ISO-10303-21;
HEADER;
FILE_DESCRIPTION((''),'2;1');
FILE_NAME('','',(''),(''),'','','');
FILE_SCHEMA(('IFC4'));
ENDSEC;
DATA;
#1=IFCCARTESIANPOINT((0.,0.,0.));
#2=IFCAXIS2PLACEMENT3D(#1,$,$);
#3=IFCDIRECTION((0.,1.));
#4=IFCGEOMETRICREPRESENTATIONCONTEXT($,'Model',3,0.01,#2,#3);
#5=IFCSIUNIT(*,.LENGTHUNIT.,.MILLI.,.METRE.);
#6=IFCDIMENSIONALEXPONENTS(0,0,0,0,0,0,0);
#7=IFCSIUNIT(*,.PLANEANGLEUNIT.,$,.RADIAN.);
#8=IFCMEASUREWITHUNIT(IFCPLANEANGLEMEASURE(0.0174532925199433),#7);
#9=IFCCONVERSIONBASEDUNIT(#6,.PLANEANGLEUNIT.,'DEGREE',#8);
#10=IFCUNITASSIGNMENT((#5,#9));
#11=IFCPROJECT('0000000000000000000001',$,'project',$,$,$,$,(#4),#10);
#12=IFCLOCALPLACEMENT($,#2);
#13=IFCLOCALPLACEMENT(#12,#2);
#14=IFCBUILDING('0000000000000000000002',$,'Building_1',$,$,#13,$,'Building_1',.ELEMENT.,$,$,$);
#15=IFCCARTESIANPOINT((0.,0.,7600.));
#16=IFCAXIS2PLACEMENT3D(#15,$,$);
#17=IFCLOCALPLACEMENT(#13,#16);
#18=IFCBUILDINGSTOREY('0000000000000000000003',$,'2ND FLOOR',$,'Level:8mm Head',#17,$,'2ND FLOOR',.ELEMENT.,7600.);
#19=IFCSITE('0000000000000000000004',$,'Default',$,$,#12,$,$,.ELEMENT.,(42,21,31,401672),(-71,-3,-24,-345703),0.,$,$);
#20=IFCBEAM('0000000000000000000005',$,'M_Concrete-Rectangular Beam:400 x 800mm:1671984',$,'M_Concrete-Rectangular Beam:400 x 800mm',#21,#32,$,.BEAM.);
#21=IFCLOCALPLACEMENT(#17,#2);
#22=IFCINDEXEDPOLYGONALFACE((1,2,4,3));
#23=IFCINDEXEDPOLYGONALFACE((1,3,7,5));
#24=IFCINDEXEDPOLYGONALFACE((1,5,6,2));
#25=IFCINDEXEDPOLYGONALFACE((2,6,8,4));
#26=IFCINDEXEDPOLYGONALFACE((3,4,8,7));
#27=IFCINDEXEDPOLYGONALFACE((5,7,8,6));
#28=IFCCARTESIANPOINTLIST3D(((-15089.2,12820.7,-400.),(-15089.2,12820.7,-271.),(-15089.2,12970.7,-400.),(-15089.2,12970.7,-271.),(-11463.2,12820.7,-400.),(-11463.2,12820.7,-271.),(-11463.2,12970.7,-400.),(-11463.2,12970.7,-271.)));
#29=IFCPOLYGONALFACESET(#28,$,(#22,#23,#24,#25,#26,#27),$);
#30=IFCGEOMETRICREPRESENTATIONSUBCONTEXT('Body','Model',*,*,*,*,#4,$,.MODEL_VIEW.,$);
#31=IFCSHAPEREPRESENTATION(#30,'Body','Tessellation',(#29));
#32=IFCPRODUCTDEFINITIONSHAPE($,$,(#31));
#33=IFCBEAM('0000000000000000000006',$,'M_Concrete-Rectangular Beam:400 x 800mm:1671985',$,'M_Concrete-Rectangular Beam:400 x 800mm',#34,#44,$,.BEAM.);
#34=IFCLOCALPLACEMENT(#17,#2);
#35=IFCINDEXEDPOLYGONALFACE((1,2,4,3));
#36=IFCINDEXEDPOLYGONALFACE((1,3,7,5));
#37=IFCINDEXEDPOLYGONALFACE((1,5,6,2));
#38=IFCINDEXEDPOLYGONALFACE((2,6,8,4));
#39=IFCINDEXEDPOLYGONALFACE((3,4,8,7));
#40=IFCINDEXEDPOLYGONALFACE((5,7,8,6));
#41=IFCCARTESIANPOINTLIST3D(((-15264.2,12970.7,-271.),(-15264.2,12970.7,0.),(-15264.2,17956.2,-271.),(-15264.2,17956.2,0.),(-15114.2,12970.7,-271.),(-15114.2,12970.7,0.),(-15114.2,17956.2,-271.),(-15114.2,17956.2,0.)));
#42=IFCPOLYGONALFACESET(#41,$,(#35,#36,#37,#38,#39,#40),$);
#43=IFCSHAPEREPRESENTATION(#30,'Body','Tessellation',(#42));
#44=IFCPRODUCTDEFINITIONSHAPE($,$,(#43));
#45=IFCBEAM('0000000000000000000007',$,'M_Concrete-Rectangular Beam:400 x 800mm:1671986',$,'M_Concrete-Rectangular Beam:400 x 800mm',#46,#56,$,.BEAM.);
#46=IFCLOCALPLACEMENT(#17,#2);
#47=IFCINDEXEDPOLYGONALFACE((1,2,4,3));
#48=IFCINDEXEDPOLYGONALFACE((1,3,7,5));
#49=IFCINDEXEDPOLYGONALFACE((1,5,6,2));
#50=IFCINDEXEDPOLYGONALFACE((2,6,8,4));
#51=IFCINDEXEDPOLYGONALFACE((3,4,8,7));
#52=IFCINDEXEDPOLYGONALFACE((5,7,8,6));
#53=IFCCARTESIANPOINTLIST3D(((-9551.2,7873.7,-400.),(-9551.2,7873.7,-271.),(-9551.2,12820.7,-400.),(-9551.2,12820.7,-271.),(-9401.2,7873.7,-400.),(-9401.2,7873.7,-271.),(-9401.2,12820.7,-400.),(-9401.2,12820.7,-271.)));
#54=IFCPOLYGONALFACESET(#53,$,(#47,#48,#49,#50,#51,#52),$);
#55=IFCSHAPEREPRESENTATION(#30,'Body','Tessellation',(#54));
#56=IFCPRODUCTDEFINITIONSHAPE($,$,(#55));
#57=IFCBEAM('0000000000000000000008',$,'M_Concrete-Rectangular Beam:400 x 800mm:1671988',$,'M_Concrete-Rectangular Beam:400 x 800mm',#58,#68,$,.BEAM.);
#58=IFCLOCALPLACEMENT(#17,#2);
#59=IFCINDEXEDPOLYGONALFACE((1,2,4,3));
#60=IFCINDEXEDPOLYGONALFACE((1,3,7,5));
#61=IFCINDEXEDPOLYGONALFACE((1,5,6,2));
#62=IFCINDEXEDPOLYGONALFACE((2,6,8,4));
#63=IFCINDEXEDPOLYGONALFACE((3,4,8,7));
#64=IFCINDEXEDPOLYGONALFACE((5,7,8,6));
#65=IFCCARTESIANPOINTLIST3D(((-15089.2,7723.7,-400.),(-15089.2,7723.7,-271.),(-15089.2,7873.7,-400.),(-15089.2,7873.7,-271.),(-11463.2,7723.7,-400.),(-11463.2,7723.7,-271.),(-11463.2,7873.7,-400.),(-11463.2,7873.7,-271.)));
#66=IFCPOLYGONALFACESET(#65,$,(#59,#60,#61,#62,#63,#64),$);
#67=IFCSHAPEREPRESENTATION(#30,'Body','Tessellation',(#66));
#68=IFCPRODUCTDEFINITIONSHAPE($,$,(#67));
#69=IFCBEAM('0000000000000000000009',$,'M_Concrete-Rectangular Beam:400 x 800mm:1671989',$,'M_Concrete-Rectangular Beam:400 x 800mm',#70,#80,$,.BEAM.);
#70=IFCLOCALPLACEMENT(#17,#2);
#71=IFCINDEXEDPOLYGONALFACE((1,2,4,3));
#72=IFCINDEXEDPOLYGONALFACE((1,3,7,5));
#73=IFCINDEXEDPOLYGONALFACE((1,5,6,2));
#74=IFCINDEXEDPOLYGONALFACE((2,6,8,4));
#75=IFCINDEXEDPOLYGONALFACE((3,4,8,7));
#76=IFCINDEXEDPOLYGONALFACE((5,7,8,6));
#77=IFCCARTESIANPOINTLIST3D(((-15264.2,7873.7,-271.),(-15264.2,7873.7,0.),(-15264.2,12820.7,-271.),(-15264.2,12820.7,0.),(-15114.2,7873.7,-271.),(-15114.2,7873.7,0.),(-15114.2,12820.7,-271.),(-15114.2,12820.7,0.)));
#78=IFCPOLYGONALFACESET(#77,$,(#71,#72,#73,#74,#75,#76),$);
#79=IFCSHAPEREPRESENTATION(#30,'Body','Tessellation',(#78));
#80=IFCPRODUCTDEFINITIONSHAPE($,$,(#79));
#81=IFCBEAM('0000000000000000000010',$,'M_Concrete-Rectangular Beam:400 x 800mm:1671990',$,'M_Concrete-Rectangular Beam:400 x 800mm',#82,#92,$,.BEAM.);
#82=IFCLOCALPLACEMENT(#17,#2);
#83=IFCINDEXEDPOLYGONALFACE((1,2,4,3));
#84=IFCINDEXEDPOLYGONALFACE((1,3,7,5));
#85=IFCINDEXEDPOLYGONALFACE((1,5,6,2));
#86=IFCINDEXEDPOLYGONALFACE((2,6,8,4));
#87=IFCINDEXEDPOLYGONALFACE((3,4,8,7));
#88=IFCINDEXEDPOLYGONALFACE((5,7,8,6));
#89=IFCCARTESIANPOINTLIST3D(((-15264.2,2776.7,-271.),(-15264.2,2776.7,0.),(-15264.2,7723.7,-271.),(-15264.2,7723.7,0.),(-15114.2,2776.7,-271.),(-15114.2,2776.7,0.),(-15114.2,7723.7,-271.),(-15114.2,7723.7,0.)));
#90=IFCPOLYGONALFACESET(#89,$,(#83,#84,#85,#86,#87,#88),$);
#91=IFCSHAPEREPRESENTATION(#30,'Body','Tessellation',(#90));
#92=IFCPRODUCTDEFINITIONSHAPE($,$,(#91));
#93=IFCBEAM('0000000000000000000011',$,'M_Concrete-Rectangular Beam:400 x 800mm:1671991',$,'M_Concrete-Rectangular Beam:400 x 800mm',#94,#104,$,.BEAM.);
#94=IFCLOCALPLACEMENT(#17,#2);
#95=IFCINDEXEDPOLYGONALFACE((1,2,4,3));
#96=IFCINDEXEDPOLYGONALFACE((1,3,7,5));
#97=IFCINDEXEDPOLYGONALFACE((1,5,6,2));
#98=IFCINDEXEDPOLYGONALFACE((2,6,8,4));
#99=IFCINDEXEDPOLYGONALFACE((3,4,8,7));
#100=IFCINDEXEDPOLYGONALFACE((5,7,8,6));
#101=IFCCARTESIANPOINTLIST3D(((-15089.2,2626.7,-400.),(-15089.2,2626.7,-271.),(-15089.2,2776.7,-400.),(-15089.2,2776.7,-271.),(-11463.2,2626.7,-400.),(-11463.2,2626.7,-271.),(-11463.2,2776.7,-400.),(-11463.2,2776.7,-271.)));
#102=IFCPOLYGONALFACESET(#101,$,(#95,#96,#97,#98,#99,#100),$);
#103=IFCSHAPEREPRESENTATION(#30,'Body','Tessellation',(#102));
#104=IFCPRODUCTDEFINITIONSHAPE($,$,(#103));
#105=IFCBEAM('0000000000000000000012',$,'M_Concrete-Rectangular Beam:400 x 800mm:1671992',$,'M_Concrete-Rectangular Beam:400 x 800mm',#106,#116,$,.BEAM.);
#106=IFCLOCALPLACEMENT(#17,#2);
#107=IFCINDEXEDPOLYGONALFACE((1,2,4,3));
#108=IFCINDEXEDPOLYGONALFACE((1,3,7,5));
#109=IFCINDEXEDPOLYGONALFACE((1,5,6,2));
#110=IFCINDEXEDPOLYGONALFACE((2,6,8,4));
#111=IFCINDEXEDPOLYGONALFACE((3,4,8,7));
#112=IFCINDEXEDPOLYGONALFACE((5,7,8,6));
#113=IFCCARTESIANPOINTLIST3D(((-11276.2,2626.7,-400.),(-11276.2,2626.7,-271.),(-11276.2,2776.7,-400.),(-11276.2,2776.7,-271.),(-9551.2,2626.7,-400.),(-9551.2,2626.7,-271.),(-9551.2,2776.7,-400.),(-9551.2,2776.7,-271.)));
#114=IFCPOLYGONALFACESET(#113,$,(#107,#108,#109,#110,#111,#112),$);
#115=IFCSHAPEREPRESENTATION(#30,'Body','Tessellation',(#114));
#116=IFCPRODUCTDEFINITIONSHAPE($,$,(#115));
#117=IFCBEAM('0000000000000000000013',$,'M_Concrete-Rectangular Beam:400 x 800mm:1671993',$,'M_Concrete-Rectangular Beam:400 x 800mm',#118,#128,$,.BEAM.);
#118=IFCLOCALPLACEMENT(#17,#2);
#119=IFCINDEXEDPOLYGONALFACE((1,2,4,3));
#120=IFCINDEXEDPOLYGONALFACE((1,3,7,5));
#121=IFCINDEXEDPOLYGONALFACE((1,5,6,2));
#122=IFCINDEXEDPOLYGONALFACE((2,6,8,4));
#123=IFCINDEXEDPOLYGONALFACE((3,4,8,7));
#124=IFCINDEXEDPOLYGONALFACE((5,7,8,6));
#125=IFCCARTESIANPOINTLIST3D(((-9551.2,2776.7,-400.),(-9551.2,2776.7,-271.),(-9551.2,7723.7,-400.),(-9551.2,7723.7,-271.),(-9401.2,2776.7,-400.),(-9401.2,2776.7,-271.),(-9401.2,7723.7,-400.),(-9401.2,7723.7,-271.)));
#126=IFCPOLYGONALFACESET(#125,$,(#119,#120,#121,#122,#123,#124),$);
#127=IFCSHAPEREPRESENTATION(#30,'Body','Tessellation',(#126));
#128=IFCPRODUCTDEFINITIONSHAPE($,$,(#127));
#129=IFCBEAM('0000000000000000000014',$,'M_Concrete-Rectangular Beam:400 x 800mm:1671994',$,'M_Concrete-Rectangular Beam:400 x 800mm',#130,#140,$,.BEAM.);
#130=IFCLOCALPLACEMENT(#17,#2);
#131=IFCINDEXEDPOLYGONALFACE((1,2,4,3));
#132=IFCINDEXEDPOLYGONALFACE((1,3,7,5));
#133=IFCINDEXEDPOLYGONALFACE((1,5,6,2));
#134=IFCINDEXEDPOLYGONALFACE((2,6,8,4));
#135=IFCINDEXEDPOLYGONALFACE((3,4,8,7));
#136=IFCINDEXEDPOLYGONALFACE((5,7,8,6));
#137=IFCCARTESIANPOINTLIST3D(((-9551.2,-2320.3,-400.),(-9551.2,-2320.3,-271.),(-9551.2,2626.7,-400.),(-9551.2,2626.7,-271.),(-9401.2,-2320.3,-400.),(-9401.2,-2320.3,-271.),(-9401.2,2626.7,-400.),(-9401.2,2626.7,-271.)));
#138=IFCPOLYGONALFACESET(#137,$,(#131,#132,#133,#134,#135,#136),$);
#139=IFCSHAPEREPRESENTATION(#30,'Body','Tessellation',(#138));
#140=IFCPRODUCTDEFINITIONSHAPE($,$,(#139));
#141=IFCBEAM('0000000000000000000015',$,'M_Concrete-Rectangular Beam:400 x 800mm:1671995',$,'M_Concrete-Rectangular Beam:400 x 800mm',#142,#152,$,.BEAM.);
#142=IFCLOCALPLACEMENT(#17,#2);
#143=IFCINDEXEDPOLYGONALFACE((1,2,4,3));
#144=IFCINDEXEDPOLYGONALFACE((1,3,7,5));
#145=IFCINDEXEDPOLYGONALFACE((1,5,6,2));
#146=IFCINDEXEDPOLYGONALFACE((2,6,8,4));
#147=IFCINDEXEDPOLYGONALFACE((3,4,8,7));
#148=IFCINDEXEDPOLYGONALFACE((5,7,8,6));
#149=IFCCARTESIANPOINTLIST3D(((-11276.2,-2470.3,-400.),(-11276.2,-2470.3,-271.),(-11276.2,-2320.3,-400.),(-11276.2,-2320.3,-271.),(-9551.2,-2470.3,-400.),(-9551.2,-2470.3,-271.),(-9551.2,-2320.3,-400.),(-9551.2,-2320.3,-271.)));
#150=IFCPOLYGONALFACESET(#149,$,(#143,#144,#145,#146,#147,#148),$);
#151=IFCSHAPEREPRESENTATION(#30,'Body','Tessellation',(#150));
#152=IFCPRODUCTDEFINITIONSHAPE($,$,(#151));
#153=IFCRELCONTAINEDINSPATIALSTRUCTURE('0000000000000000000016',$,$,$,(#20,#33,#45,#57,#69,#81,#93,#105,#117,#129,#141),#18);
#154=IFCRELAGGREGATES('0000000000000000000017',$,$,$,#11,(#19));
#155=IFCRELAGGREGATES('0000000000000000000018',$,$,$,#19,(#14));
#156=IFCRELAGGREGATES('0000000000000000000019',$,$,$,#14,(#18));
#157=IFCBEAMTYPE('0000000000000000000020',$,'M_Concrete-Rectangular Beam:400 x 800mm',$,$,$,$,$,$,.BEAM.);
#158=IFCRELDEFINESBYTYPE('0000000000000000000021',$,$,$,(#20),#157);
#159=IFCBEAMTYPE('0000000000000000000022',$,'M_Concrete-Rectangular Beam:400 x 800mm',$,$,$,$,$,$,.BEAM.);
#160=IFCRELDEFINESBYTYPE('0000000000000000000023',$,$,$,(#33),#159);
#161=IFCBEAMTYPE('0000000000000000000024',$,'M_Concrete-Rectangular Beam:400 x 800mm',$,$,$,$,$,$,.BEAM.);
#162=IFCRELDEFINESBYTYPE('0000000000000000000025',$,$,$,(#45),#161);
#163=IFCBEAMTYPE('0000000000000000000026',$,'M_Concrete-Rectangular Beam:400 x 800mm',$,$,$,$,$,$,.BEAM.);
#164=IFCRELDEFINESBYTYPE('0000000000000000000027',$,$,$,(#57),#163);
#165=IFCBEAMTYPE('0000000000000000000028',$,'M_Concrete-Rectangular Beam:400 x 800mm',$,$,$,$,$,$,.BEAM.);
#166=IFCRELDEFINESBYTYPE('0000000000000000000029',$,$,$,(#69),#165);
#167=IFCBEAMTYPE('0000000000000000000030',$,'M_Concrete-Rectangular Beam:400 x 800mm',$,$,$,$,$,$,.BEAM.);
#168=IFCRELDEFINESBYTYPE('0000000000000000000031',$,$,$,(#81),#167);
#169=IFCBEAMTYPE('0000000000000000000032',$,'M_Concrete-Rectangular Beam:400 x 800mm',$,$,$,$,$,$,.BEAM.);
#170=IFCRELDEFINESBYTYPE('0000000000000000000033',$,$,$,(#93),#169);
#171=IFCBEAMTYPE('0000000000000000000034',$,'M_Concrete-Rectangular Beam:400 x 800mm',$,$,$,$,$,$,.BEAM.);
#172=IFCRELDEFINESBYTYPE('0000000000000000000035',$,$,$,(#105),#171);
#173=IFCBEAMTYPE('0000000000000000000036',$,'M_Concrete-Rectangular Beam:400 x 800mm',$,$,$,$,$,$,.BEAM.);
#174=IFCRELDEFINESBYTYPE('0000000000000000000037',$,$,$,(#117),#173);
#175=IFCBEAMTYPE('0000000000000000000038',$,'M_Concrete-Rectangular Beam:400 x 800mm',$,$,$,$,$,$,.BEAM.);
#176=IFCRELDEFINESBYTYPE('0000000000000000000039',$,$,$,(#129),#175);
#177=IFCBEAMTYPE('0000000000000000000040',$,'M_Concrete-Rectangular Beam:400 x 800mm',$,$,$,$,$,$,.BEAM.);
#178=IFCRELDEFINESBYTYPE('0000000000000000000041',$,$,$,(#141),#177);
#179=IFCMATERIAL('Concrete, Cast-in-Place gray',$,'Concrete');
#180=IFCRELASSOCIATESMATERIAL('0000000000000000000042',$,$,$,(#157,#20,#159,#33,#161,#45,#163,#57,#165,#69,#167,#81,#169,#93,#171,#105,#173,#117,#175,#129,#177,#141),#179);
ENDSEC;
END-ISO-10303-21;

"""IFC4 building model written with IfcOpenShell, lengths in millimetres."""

from ifc_helpers import new_model, entity, si_unit, converted_unit, direction, frame, origin, place, context, subcontext, project, spatial, indexed_curve, outline, extrude, source, transform, mapped, material, type_object, type_shapes, element, save


model = new_model("IFC4")

# Units and contexts
model_context = context("Model", 3, precision=0.01, world=origin(), true_north=direction((0.0, 1.0)))
body_context = subcontext(model_context, "Body", "Model", "MODEL_VIEW")
ifc_project = project(units=[si_unit("LENGTHUNIT", "METRE", prefix="MILLI"), converted_unit("PLANEANGLEUNIT", "DEGREE", entity("IfcPlaneAngleMeasure", 0.0174532925199433), si_unit("PLANEANGLEUNIT", "RADIAN"), dimensions=[0, 0, 0, 0, 0, 0, 0])], contexts=[model_context])

# Site, building, storey
site_placement = place(None, origin())
site = spatial("IfcSite", under=ifc_project, at=site_placement, Name="Default", CompositionType="ELEMENT", RefLatitude=(42, 21, 31, 401672), RefLongitude=(-71, -3, -24, -345703), RefElevation=0.0)
building_placement = place(site_placement, origin())
building = spatial("IfcBuilding", under=site, at=building_placement, Name="Building_1", LongName="Building_1", CompositionType="ELEMENT")
storey_placement = place(building_placement, frame((0.0, 0.0, 7600.0)))
storey = spatial("IfcBuildingStorey", under=building, at=storey_placement, Name="2ND FLOOR", ObjectType="Level:8mm Head", LongName="2ND FLOOR", CompositionType="ELEMENT", Elevation=7600.0)

# Beams
ifc_material = material(Name="Concrete, Cast-in-Place gray", Category="Concrete")
beam_type_1 = type_object("IfcBeamType", Name="M_Concrete-Rectangular Beam:400 x 800mm", PredefinedType="BEAM", material=ifc_material)
shared_shape_1 = source(origin(), body_context, "Body", "SweptSolid", [
    extrude(outline(indexed_curve([(-64.5, -75.0), (64.5, -75.0), (64.5, 75.0), (-64.5, 75.0), (-64.5, -75.0)], self_intersect=False)), frame((-11463.2, 12895.7, 7264.5), z_axis=(-1.0, 0.0, 0.0), x_axis=(0.0, 0.0, -1.0)), (0.0, 0.0, 1.0), 3626.0),
])
type_shapes(beam_type_1, [shared_shape_1])
beam_1_placement = place(storey_placement, frame((0.0, 0.0, -7600.0)))
element("IfcBeam", 1, at=beam_1_placement, inside=storey, type_object=beam_type_1, material=ifc_material, Name="M_Concrete-Rectangular Beam:400 x 800mm:1671984", ObjectType="M_Concrete-Rectangular Beam:400 x 800mm", PredefinedType="BEAM", context=body_context, shape_type="MappedRepresentation", body=[
    mapped(shared_shape_1, transform((0.0, 0.0, 0.0), scale=1.0)),
])
beam_type_2 = type_object("IfcBeamType", Name="M_Concrete-Rectangular Beam:400 x 800mm", PredefinedType="BEAM", material=ifc_material)
shared_shape_2 = source(origin(), body_context, "Body", "SweptSolid", [
    extrude(outline(indexed_curve([(-75.0, -135.5), (75.0, -135.5), (75.0, 135.5), (-75.0, 135.5), (-75.0, -135.5)], self_intersect=False)), frame((-15189.2, 12970.7, 7464.5), z_axis=(0.0, 1.0, 0.0), x_axis=(-1.0, 0.0, 0.0)), (0.0, 0.0, 1.0), 4985.5),
])
type_shapes(beam_type_2, [shared_shape_2])
beam_2_placement = place(storey_placement, frame((0.0, 0.0, -7600.0)))
element("IfcBeam", 2, at=beam_2_placement, inside=storey, type_object=beam_type_2, material=ifc_material, Name="M_Concrete-Rectangular Beam:400 x 800mm:1671985", ObjectType="M_Concrete-Rectangular Beam:400 x 800mm", PredefinedType="BEAM", context=body_context, shape_type="MappedRepresentation", body=[
    mapped(shared_shape_2, transform((0.0, 0.0, 0.0), scale=1.0)),
])
beam_type_3 = type_object("IfcBeamType", Name="M_Concrete-Rectangular Beam:400 x 800mm", PredefinedType="BEAM", material=ifc_material)
shared_shape_3 = source(origin(), body_context, "Body", "SweptSolid", [
    extrude(outline(indexed_curve([(-75.0, -64.5), (75.0, -64.5), (75.0, 64.5), (-75.0, 64.5), (-75.0, -64.5)], self_intersect=False)), frame((-9476.2, 12820.7, 7264.5), z_axis=(0.0, -1.0, 0.0), x_axis=(-1.0, 0.0, 0.0)), (0.0, 0.0, 1.0), 4947.0),
])
type_shapes(beam_type_3, [shared_shape_3])
beam_3_placement = place(storey_placement, frame((0.0, 0.0, -7600.0)))
element("IfcBeam", 3, at=beam_3_placement, inside=storey, type_object=beam_type_3, material=ifc_material, Name="M_Concrete-Rectangular Beam:400 x 800mm:1671986", ObjectType="M_Concrete-Rectangular Beam:400 x 800mm", PredefinedType="BEAM", context=body_context, shape_type="MappedRepresentation", body=[
    mapped(shared_shape_3, transform((0.0, 0.0, 0.0), scale=1.0)),
])
beam_type_4 = type_object("IfcBeamType", Name="M_Concrete-Rectangular Beam:400 x 800mm", PredefinedType="BEAM", material=ifc_material)
shared_shape_4 = source(origin(), body_context, "Body", "SweptSolid", [
    extrude(outline(indexed_curve([(-64.5, -75.0), (64.5, -75.0), (64.5, 75.0), (-64.5, 75.0), (-64.5, -75.0)], self_intersect=False)), frame((-11463.2, 7798.7, 7264.5), z_axis=(-1.0, 0.0, 0.0), x_axis=(0.0, 0.0, -1.0)), (0.0, 0.0, 1.0), 3626.0),
])
type_shapes(beam_type_4, [shared_shape_4])
beam_4_placement = place(storey_placement, frame((0.0, 0.0, -7600.0)))
element("IfcBeam", 4, at=beam_4_placement, inside=storey, type_object=beam_type_4, material=ifc_material, Name="M_Concrete-Rectangular Beam:400 x 800mm:1671988", ObjectType="M_Concrete-Rectangular Beam:400 x 800mm", PredefinedType="BEAM", context=body_context, shape_type="MappedRepresentation", body=[
    mapped(shared_shape_4, transform((0.0, 0.0, 0.0), scale=1.0)),
])
beam_type_5 = type_object("IfcBeamType", Name="M_Concrete-Rectangular Beam:400 x 800mm", PredefinedType="BEAM", material=ifc_material)
shared_shape_5 = source(origin(), body_context, "Body", "SweptSolid", [
    extrude(outline(indexed_curve([(-75.0, -135.5), (75.0, -135.5), (75.0, 135.5), (-75.0, 135.5), (-75.0, -135.5)], self_intersect=False)), frame((-15189.2, 12820.7, 7464.5), z_axis=(0.0, -1.0, 0.0), x_axis=(-1.0, 0.0, 0.0)), (0.0, 0.0, 1.0), 4947.0),
])
type_shapes(beam_type_5, [shared_shape_5])
beam_5_placement = place(storey_placement, frame((0.0, 0.0, -7600.0)))
element("IfcBeam", 5, at=beam_5_placement, inside=storey, type_object=beam_type_5, material=ifc_material, Name="M_Concrete-Rectangular Beam:400 x 800mm:1671989", ObjectType="M_Concrete-Rectangular Beam:400 x 800mm", PredefinedType="BEAM", context=body_context, shape_type="MappedRepresentation", body=[
    mapped(shared_shape_5, transform((0.0, 0.0, 0.0), scale=1.0)),
])
beam_type_6 = type_object("IfcBeamType", Name="M_Concrete-Rectangular Beam:400 x 800mm", PredefinedType="BEAM", material=ifc_material)
shared_shape_6 = source(origin(), body_context, "Body", "SweptSolid", [
    extrude(outline(indexed_curve([(-75.0, -135.5), (75.0, -135.5), (75.0, 135.5), (-75.0, 135.5), (-75.0, -135.5)], self_intersect=False)), frame((-15189.2, 7723.7, 7464.5), z_axis=(0.0, -1.0, 0.0), x_axis=(-1.0, 0.0, 0.0)), (0.0, 0.0, 1.0), 4947.0),
])
type_shapes(beam_type_6, [shared_shape_6])
beam_6_placement = place(storey_placement, frame((0.0, 0.0, -7600.0)))
element("IfcBeam", 6, at=beam_6_placement, inside=storey, type_object=beam_type_6, material=ifc_material, Name="M_Concrete-Rectangular Beam:400 x 800mm:1671990", ObjectType="M_Concrete-Rectangular Beam:400 x 800mm", PredefinedType="BEAM", context=body_context, shape_type="MappedRepresentation", body=[
    mapped(shared_shape_6, transform((0.0, 0.0, 0.0), scale=1.0)),
])
beam_type_7 = type_object("IfcBeamType", Name="M_Concrete-Rectangular Beam:400 x 800mm", PredefinedType="BEAM", material=ifc_material)
shared_shape_7 = source(origin(), body_context, "Body", "SweptSolid", [
    extrude(outline(indexed_curve([(-64.5, -75.0), (64.5, -75.0), (64.5, 75.0), (-64.5, 75.0), (-64.5, -75.0)], self_intersect=False)), frame((-15089.2, 2701.7, 7264.5), z_axis=(1.0, 0.0, 0.0), x_axis=(0.0, 0.0, -1.0)), (0.0, 0.0, 1.0), 3626.0),
])
type_shapes(beam_type_7, [shared_shape_7])
beam_7_placement = place(storey_placement, frame((0.0, 0.0, -7600.0)))
element("IfcBeam", 7, at=beam_7_placement, inside=storey, type_object=beam_type_7, material=ifc_material, Name="M_Concrete-Rectangular Beam:400 x 800mm:1671991", ObjectType="M_Concrete-Rectangular Beam:400 x 800mm", PredefinedType="BEAM", context=body_context, shape_type="MappedRepresentation", body=[
    mapped(shared_shape_7, transform((0.0, 0.0, 0.0), scale=1.0)),
])
beam_type_8 = type_object("IfcBeamType", Name="M_Concrete-Rectangular Beam:400 x 800mm", PredefinedType="BEAM", material=ifc_material)
shared_shape_8 = source(origin(), body_context, "Body", "SweptSolid", [
    extrude(outline(indexed_curve([(-64.5, -75.0), (64.5, -75.0), (64.5, 75.0), (-64.5, 75.0), (-64.5, -75.0)], self_intersect=False)), frame((-11276.2, 2701.7, 7264.5), z_axis=(1.0, 0.0, 0.0), x_axis=(0.0, 0.0, -1.0)), (0.0, 0.0, 1.0), 1725.0),
])
type_shapes(beam_type_8, [shared_shape_8])
beam_8_placement = place(storey_placement, frame((0.0, 0.0, -7600.0)))
element("IfcBeam", 8, at=beam_8_placement, inside=storey, type_object=beam_type_8, material=ifc_material, Name="M_Concrete-Rectangular Beam:400 x 800mm:1671992", ObjectType="M_Concrete-Rectangular Beam:400 x 800mm", PredefinedType="BEAM", context=body_context, shape_type="MappedRepresentation", body=[
    mapped(shared_shape_8, transform((0.0, 0.0, 0.0), scale=1.0)),
])
beam_type_9 = type_object("IfcBeamType", Name="M_Concrete-Rectangular Beam:400 x 800mm", PredefinedType="BEAM", material=ifc_material)
shared_shape_9 = source(origin(), body_context, "Body", "SweptSolid", [
    extrude(outline(indexed_curve([(-75.0, -64.5), (75.0, -64.5), (75.0, 64.5), (-75.0, 64.5), (-75.0, -64.5)], self_intersect=False)), frame((-9476.2, 2776.7, 7264.5), z_axis=(0.0, 1.0, 0.0), x_axis=(-1.0, 0.0, 0.0)), (0.0, 0.0, 1.0), 4947.0),
])
type_shapes(beam_type_9, [shared_shape_9])
beam_9_placement = place(storey_placement, frame((0.0, 0.0, -7600.0)))
element("IfcBeam", 9, at=beam_9_placement, inside=storey, type_object=beam_type_9, material=ifc_material, Name="M_Concrete-Rectangular Beam:400 x 800mm:1671993", ObjectType="M_Concrete-Rectangular Beam:400 x 800mm", PredefinedType="BEAM", context=body_context, shape_type="MappedRepresentation", body=[
    mapped(shared_shape_9, transform((0.0, 0.0, 0.0), scale=1.0)),
])
beam_type_10 = type_object("IfcBeamType", Name="M_Concrete-Rectangular Beam:400 x 800mm", PredefinedType="BEAM", material=ifc_material)
shared_shape_10 = source(origin(), body_context, "Body", "SweptSolid", [
    extrude(outline(indexed_curve([(-75.0, -64.5), (75.0, -64.5), (75.0, 64.5), (-75.0, 64.5), (-75.0, -64.5)], self_intersect=False)), frame((-9476.2, 2626.7, 7264.5), z_axis=(0.0, -1.0, 0.0), x_axis=(-1.0, 0.0, 0.0)), (0.0, 0.0, 1.0), 4947.0),
])
type_shapes(beam_type_10, [shared_shape_10])
beam_10_placement = place(storey_placement, frame((0.0, 0.0, -7600.0)))
element("IfcBeam", 10, at=beam_10_placement, inside=storey, type_object=beam_type_10, material=ifc_material, Name="M_Concrete-Rectangular Beam:400 x 800mm:1671994", ObjectType="M_Concrete-Rectangular Beam:400 x 800mm", PredefinedType="BEAM", context=body_context, shape_type="MappedRepresentation", body=[
    mapped(shared_shape_10, transform((0.0, 0.0, 0.0), scale=1.0)),
])
beam_type_11 = type_object("IfcBeamType", Name="M_Concrete-Rectangular Beam:400 x 800mm", PredefinedType="BEAM", material=ifc_material)
shared_shape_11 = source(origin(), body_context, "Body", "SweptSolid", [
    extrude(outline(indexed_curve([(-64.5, -75.0), (64.5, -75.0), (64.5, 75.0), (-64.5, 75.0), (-64.5, -75.0)], self_intersect=False)), frame((-9551.2, -2395.3, 7264.5), z_axis=(-1.0, 0.0, 0.0), x_axis=(0.0, 0.0, -1.0)), (0.0, 0.0, 1.0), 1725.0),
])
type_shapes(beam_type_11, [shared_shape_11])
beam_11_placement = place(storey_placement, frame((0.0, 0.0, -7600.0)))
element("IfcBeam", 11, at=beam_11_placement, inside=storey, type_object=beam_type_11, material=ifc_material, Name="M_Concrete-Rectangular Beam:400 x 800mm:1671995", ObjectType="M_Concrete-Rectangular Beam:400 x 800mm", PredefinedType="BEAM", context=body_context, shape_type="MappedRepresentation", body=[
    mapped(shared_shape_11, transform((0.0, 0.0, 0.0), scale=1.0)),
])

save(model, "model.ifc")
